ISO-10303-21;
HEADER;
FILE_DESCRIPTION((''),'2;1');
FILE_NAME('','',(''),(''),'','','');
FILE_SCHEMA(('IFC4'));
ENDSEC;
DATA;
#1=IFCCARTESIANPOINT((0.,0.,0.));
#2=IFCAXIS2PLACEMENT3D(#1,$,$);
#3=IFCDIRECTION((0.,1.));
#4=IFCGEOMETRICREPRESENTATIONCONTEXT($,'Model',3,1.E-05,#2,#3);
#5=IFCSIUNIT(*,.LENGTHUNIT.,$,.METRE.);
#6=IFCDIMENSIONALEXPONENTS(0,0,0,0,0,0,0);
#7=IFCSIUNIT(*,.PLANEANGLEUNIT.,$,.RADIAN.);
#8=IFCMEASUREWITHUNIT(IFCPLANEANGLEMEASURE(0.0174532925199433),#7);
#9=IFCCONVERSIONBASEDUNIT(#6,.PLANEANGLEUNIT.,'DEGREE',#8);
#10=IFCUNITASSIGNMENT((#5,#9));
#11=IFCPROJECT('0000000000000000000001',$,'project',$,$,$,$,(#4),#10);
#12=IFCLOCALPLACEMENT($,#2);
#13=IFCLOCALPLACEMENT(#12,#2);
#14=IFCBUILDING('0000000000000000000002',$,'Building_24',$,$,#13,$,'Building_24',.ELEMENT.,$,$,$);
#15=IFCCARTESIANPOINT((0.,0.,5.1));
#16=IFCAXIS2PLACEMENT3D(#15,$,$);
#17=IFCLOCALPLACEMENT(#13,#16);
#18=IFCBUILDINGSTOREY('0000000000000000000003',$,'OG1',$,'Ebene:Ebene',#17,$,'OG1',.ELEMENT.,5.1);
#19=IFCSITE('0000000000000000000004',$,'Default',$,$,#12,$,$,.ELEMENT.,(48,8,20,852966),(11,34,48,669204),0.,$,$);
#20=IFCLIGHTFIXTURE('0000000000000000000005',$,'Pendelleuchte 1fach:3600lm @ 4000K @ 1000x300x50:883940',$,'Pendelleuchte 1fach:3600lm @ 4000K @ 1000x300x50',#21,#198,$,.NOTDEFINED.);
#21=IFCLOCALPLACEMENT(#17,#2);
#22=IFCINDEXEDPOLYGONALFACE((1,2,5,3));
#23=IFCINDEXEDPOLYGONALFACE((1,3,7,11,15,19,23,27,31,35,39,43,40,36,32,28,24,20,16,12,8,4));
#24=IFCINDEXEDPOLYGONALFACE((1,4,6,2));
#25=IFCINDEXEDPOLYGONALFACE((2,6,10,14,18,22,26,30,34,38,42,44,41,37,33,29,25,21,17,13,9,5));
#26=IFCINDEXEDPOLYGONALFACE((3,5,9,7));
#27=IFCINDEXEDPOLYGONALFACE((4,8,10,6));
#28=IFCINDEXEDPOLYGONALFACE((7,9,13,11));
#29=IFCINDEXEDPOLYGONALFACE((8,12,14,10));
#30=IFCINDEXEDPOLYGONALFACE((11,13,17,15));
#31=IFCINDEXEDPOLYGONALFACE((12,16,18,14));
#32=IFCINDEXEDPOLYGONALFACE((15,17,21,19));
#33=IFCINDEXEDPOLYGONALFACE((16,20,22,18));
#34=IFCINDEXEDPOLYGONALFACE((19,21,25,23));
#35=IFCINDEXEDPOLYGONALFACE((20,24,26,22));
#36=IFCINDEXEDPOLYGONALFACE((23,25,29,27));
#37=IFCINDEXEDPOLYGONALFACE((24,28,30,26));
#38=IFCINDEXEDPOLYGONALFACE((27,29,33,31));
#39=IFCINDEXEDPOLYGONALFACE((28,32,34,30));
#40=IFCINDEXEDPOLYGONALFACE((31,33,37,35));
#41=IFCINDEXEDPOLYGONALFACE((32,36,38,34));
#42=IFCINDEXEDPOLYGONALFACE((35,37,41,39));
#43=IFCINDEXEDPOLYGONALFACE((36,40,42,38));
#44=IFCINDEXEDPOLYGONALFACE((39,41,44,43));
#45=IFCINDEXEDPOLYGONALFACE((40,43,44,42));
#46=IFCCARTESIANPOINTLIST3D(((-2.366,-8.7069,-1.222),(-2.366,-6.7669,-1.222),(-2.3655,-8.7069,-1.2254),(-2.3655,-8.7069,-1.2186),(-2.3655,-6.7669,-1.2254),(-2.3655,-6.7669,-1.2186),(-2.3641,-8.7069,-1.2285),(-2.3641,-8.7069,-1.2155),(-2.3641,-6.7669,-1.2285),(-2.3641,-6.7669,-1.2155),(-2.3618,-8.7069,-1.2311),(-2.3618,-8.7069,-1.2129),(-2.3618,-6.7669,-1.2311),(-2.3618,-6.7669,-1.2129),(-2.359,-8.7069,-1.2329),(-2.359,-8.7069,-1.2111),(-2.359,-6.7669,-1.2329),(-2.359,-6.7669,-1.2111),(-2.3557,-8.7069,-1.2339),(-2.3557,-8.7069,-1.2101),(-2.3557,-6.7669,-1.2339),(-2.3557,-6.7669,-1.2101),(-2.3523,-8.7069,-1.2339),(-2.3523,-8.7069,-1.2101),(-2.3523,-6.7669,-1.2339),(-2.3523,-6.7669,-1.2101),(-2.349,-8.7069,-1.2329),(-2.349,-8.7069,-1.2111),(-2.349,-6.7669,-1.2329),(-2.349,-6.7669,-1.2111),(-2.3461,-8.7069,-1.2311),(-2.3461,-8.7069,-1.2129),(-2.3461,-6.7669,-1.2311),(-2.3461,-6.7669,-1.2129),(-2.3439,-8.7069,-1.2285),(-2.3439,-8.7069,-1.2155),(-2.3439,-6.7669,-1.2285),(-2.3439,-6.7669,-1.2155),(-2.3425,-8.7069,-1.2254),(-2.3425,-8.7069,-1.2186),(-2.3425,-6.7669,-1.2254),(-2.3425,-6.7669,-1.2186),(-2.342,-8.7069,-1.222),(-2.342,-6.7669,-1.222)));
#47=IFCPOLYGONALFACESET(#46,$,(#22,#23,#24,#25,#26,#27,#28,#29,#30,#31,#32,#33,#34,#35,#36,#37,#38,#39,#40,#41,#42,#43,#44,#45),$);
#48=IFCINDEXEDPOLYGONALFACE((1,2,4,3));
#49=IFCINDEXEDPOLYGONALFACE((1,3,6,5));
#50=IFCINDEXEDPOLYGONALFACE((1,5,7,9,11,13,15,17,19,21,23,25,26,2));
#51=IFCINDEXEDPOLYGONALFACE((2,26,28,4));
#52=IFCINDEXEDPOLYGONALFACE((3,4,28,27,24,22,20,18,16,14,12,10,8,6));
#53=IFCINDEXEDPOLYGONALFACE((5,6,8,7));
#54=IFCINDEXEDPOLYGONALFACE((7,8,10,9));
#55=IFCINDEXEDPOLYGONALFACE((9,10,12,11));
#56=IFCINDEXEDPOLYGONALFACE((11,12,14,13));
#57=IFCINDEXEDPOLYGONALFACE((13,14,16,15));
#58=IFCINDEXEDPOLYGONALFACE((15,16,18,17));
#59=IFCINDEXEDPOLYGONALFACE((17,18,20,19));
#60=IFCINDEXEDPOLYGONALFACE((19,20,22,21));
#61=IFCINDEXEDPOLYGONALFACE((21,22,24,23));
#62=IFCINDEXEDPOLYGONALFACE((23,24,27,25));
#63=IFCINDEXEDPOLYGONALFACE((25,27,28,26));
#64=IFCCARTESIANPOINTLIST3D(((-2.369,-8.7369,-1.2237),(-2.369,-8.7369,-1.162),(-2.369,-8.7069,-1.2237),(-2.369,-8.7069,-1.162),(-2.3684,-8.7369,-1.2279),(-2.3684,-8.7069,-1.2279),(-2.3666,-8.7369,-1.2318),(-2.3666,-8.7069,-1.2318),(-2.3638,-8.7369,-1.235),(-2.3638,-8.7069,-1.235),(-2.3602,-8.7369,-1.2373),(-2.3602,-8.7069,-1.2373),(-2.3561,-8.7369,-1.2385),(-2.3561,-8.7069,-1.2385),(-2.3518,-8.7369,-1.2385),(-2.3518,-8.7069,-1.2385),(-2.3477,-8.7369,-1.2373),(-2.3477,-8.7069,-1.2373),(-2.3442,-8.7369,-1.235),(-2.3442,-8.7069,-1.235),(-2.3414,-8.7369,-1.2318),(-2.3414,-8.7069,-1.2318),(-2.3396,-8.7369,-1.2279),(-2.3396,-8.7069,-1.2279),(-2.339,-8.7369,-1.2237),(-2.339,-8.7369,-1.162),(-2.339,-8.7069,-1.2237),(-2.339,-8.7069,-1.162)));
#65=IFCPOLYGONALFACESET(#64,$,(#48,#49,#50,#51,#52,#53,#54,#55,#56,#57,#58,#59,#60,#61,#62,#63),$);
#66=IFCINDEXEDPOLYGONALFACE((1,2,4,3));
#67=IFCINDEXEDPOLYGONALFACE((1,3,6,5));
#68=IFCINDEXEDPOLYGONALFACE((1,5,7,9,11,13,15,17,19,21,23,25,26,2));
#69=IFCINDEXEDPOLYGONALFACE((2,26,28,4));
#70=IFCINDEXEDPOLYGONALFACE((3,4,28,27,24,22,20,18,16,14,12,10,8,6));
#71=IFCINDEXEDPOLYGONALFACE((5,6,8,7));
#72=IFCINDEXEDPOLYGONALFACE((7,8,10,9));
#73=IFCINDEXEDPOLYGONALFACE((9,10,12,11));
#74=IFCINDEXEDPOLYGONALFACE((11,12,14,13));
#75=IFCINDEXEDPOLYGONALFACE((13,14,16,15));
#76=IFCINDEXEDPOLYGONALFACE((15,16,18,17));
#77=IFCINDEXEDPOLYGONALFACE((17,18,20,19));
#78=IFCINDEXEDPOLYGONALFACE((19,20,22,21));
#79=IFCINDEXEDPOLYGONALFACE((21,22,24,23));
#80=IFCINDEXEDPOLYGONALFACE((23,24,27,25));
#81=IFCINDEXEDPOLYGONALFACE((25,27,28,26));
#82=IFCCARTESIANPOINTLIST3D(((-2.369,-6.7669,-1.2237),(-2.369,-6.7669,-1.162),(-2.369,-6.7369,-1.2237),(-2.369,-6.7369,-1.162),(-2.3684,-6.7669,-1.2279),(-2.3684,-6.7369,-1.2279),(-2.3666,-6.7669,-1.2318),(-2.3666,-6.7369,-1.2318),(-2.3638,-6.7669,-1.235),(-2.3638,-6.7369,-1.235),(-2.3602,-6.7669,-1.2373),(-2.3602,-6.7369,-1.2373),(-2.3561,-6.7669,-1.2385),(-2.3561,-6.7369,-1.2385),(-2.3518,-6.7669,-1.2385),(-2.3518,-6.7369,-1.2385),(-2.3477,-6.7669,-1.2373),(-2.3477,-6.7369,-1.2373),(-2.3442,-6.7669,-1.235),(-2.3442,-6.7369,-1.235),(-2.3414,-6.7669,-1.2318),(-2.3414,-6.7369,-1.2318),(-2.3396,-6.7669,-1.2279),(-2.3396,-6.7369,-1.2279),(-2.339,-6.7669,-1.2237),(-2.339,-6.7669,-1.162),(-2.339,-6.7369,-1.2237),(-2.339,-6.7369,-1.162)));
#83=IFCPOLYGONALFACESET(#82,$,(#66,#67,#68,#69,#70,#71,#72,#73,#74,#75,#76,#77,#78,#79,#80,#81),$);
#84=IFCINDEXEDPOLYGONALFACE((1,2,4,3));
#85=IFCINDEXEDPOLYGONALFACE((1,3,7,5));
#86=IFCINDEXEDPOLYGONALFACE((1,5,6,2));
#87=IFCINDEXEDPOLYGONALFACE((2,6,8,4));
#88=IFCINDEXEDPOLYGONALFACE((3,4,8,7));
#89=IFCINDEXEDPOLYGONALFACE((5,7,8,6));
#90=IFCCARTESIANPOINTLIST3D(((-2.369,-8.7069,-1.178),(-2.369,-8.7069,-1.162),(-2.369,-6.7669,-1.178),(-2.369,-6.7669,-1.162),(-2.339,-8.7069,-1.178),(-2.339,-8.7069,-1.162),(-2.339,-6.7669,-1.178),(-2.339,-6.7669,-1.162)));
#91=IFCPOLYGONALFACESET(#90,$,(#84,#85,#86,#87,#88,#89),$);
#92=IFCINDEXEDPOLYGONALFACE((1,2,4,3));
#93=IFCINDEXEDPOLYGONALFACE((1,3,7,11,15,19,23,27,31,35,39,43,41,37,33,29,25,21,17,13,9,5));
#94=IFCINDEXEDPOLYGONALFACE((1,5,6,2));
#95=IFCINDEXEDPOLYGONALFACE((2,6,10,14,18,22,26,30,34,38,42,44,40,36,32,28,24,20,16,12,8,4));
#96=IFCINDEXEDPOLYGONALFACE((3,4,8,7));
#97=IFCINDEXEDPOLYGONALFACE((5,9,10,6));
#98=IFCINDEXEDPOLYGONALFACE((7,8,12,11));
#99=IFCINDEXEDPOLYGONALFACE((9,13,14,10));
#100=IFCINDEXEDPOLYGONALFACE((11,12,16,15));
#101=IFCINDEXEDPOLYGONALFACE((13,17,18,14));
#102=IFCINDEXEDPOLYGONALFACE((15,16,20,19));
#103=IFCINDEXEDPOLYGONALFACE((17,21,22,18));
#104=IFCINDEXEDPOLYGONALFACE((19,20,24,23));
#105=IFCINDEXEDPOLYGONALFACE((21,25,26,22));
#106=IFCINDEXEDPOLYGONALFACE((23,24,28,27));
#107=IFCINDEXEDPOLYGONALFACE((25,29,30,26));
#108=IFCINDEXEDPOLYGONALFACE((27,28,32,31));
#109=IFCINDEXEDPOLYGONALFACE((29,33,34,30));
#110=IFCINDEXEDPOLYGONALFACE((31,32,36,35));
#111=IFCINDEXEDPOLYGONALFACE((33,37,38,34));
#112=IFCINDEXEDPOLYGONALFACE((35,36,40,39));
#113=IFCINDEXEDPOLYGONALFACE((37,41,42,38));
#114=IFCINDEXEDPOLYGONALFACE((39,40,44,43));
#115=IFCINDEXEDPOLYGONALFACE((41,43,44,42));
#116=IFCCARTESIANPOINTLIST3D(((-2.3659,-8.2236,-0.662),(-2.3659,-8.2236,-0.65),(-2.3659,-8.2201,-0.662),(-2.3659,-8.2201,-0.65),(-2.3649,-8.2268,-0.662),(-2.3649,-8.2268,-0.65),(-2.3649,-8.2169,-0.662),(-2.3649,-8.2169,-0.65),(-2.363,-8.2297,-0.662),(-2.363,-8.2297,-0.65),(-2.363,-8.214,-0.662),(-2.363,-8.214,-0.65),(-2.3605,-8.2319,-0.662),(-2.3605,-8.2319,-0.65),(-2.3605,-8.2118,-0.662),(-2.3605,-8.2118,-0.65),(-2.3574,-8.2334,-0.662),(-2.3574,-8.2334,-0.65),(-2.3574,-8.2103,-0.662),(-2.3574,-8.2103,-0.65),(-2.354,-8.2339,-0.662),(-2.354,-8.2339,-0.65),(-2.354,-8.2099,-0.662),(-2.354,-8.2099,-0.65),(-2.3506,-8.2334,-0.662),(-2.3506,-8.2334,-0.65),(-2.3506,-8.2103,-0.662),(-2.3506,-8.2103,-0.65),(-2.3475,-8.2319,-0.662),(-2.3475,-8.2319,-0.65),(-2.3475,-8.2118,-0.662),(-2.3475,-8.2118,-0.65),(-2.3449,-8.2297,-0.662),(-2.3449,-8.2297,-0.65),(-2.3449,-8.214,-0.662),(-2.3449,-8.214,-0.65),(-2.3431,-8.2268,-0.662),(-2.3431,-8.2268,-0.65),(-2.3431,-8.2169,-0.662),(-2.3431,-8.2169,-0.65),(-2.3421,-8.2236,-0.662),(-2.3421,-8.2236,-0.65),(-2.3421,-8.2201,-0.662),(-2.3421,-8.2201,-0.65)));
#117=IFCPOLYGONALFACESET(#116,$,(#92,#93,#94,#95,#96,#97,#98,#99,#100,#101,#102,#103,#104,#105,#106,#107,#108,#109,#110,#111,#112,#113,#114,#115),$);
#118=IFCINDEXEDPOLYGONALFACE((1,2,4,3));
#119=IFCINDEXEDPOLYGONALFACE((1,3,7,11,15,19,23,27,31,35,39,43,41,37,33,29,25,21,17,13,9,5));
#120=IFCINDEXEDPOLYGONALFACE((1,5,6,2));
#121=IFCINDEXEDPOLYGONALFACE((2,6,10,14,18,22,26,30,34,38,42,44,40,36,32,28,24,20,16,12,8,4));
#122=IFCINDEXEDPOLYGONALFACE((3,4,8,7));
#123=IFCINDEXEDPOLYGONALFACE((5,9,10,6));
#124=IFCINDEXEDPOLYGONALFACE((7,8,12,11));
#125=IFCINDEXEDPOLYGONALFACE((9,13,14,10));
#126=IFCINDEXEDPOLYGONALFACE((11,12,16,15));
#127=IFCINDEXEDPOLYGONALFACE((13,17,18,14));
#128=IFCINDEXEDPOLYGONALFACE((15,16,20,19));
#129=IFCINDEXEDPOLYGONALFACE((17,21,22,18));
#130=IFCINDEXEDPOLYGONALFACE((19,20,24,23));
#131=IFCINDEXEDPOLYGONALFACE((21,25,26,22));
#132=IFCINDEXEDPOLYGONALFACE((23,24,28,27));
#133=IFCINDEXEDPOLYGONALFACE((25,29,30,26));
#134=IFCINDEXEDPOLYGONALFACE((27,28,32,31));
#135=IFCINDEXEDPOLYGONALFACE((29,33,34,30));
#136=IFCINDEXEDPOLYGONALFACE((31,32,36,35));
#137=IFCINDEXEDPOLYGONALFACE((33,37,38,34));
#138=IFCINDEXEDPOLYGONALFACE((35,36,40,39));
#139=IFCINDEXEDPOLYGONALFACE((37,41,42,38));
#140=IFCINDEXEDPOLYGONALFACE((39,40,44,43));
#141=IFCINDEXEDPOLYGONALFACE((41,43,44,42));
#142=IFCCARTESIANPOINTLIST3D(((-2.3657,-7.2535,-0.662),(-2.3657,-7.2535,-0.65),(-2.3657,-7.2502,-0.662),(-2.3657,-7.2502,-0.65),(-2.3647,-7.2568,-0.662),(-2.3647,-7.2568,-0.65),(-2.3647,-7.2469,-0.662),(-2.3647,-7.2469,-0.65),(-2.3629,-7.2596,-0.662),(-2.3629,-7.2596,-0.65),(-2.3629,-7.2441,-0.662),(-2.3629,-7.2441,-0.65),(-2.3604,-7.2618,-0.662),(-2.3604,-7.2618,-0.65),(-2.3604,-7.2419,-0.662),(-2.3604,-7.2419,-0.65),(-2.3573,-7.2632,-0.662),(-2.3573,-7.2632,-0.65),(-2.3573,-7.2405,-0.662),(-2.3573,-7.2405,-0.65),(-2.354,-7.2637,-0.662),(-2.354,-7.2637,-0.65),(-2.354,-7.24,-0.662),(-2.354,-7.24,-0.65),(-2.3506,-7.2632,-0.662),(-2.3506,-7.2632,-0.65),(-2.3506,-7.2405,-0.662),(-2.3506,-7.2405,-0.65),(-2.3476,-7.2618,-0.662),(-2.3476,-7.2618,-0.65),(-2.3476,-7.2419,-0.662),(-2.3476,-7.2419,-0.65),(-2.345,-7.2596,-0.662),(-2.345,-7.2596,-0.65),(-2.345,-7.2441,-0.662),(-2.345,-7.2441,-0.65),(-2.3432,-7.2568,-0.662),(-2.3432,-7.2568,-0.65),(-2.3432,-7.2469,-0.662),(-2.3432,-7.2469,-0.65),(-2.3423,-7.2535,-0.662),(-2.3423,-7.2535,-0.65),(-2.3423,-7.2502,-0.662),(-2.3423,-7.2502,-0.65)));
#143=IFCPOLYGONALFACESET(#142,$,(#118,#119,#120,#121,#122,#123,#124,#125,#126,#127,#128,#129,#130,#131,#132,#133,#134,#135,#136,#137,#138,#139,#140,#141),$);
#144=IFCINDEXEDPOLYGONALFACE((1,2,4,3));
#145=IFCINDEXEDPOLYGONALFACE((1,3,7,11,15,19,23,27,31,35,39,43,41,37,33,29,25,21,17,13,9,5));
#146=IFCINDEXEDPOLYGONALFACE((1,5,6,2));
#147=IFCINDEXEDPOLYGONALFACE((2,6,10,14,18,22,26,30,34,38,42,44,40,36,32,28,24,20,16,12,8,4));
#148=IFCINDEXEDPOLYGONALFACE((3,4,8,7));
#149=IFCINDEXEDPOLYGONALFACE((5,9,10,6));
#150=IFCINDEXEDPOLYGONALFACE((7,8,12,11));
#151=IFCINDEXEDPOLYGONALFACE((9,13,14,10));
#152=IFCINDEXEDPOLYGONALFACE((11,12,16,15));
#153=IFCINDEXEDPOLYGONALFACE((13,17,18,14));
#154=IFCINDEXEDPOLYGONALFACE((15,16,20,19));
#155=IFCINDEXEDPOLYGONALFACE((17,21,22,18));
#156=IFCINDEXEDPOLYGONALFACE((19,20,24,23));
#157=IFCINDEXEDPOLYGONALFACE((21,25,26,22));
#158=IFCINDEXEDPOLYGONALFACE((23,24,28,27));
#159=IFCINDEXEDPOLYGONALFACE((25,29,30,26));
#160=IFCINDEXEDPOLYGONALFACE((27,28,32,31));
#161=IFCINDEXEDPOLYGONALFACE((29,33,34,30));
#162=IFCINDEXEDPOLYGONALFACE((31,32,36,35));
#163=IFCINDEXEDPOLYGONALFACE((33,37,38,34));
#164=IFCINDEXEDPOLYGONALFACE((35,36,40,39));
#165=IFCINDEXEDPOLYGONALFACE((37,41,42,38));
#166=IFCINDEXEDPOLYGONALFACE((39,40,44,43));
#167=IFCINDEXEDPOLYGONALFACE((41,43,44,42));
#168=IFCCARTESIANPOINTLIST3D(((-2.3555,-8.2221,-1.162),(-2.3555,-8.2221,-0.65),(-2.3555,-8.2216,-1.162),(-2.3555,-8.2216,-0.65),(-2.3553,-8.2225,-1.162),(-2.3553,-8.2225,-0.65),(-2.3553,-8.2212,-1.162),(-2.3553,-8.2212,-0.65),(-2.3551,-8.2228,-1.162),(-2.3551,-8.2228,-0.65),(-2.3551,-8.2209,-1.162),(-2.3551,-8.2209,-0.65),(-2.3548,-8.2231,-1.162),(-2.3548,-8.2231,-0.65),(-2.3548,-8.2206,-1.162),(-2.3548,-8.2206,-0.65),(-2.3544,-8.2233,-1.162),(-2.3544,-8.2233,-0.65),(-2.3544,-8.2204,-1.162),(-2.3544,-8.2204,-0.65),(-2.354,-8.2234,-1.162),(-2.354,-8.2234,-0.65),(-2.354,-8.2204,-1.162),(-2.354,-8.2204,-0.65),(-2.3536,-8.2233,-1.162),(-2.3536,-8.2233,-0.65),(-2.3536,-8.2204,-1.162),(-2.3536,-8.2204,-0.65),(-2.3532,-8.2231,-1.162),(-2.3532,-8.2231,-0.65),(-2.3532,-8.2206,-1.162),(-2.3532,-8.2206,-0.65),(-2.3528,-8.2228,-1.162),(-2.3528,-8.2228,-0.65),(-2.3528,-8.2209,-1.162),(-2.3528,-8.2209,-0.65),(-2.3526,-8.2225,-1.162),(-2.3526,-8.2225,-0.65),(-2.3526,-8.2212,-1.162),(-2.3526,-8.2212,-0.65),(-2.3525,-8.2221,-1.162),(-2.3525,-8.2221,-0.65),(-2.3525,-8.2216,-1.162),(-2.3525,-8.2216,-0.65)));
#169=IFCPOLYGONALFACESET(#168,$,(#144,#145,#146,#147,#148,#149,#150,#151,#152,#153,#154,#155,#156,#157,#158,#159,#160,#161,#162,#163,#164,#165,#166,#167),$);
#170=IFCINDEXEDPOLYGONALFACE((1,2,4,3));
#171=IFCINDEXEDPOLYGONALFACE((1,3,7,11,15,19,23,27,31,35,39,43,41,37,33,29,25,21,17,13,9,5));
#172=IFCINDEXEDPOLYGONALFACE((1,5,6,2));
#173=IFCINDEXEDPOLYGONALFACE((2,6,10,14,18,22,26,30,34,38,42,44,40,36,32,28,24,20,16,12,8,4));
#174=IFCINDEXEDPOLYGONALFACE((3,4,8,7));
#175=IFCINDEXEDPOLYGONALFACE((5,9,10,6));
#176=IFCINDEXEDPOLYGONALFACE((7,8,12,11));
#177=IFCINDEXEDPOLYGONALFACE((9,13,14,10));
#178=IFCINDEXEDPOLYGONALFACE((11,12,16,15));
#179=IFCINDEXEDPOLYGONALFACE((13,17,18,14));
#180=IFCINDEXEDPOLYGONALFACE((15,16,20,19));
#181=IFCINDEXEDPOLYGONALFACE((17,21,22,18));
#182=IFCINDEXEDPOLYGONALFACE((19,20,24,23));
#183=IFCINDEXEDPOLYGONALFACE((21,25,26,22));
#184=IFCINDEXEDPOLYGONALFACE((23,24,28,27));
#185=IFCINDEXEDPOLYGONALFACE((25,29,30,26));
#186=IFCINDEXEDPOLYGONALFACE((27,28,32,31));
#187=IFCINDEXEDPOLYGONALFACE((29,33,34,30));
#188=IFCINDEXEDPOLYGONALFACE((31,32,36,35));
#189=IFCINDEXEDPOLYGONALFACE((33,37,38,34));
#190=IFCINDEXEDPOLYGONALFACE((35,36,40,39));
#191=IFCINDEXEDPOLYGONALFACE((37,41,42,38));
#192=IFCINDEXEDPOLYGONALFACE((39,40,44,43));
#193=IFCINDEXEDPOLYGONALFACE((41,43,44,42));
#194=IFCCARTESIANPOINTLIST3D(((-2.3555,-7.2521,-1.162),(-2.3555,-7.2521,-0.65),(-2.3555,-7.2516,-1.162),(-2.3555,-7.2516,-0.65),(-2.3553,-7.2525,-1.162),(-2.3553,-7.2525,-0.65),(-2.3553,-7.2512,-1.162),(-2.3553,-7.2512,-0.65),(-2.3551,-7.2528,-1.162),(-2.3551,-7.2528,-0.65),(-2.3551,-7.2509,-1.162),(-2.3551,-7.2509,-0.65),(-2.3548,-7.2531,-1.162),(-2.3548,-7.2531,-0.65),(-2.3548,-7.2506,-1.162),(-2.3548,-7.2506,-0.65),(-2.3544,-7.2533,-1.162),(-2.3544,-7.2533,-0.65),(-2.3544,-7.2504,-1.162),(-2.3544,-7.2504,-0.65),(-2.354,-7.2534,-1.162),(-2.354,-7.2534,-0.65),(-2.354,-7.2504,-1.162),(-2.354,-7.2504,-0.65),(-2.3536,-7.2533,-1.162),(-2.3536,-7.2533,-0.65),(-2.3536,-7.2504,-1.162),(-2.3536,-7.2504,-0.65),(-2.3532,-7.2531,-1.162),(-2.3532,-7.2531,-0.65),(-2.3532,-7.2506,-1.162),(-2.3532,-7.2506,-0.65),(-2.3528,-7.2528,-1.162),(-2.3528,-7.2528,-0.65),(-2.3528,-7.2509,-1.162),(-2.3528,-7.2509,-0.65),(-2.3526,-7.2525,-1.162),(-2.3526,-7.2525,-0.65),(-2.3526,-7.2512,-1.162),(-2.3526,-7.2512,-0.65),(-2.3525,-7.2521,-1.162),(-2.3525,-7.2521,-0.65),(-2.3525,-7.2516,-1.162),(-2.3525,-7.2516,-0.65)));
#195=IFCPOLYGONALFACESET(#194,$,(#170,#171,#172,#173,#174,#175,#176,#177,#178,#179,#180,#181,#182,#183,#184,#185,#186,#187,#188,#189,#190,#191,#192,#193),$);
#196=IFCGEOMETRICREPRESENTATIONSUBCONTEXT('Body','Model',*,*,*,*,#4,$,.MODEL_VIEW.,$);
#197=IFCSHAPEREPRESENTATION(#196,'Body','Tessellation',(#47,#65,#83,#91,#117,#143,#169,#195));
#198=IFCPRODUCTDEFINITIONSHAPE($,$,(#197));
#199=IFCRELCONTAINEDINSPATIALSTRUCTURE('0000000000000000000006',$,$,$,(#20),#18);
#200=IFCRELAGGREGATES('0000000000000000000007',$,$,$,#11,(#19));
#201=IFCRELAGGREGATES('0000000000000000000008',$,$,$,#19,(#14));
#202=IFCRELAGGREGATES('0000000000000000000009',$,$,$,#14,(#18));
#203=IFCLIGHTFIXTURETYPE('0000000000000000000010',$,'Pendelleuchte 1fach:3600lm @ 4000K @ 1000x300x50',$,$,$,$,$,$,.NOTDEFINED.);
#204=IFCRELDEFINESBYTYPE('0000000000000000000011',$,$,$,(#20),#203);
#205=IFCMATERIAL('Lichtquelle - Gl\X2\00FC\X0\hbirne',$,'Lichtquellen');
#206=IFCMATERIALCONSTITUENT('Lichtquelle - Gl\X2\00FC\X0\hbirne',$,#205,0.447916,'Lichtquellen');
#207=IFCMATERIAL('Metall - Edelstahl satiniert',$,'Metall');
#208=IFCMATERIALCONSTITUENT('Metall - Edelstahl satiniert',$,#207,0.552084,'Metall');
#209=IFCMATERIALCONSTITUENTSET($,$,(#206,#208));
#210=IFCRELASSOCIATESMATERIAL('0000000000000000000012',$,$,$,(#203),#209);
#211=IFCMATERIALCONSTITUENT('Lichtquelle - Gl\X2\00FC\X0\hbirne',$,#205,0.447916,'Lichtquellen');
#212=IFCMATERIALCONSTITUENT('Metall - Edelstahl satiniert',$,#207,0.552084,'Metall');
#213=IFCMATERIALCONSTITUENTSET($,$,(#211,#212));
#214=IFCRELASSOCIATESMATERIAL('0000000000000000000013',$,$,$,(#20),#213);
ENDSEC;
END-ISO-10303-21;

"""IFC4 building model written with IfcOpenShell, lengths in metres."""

from ifc_helpers import new_model, entity, si_unit, converted_unit, direction, frame, origin, place, context, subcontext, project, spatial, line, arc, indexed_curve, outline, extrude, source, transform, mapped, material, constituent, constituent_set, type_object, type_shapes, element, save


model = new_model("IFC4")

# Units and contexts
model_context = context("Model", 3, precision=1e-05, world=origin(), true_north=direction((0.0, 1.0)))
body_context = subcontext(model_context, "Body", "Model", "MODEL_VIEW")
ifc_project = project(units=[si_unit("LENGTHUNIT", "METRE"), converted_unit("PLANEANGLEUNIT", "DEGREE", entity("IfcPlaneAngleMeasure", 0.0174532925199433), si_unit("PLANEANGLEUNIT", "RADIAN"), dimensions=[0, 0, 0, 0, 0, 0, 0])], contexts=[model_context])

# Site, building, storey
site_placement = place(None, origin())
site = spatial("IfcSite", under=ifc_project, at=site_placement, Name="Default", CompositionType="ELEMENT", RefLatitude=(48, 8, 20, 852966), RefLongitude=(11, 34, 48, 669204), RefElevation=0.0)
building_placement = place(site_placement, origin())
building = spatial("IfcBuilding", under=site, at=building_placement, Name="Building_24", LongName="Building_24", CompositionType="ELEMENT")
storey_placement = place(building_placement, frame((0.0, 0.0, 5.1)))
storey = spatial("IfcBuildingStorey", under=building, at=storey_placement, Name="OG1", ObjectType="Ebene:Ebene", LongName="OG1", CompositionType="ELEMENT", Elevation=5.1)

# Light fixture
ifc_material_1 = material(Name="Lichtquelle - Glühbirne", Category="Lichtquellen")
ifc_material_2 = material(Name="Metall - Edelstahl satiniert", Category="Metall")
ifc_constituent_1 = constituent(ifc_material_1, Name="Lichtquelle - Glühbirne", Category="Lichtquellen", fraction=0.447916)
ifc_constituent_2 = constituent(ifc_material_2, Name="Metall - Edelstahl satiniert", Category="Metall", fraction=0.552084)
ifc_constituent_set_1 = constituent_set(constituents=[ifc_constituent_1, ifc_constituent_2])
light_fixture_type_1 = type_object("IfcLightFixtureType", Name="Pendelleuchte 1fach:3600lm @ 4000K @ 1000x300x50", PredefinedType="NOTDEFINED", material=ifc_constituent_set_1)
shared_shape_1 = source(origin(), body_context, "Body", "SweptSolid", [
    extrude(outline(indexed_curve([(-0.012, 0.0), (0.0, -0.012), (0.012, 0.0), (0.0, 0.012)], segments=[arc(1, 2, 3), arc(3, 4, 1)], self_intersect=False)), frame((-0.97, 0.0, -0.572), z_axis=(1.0, 0.0, 0.0), x_axis=(0.0, 1.0, 0.0)), (0.0, 0.0, 1.0), 1.94),
    extrude(outline(indexed_curve([(-0.0308, -0.015), (0.0308, -0.015), (0.0308, 0.015), (-0.0308, 0.015), (-0.0458, 0.0)], segments=[line(1, 2, 3, 4), arc(4, 5, 1)], self_intersect=False)), frame((0.97, 0.0, -0.5428), z_axis=(1.0, 0.0, 0.0), x_axis=(0.0, 0.0, 1.0)), (0.0, 0.0, 1.0), 0.03),
    extrude(outline(indexed_curve([(-0.0308, -0.015), (0.0308, -0.015), (0.0308, 0.015), (-0.0308, 0.015), (-0.0458, 0.0)], segments=[line(1, 2, 3, 4), arc(4, 5, 1)], self_intersect=False)), frame((-1.0, 0.0, -0.5428), z_axis=(1.0, 0.0, 0.0), x_axis=(0.0, 0.0, 1.0)), (0.0, 0.0, 1.0), 0.03),
    extrude(outline(indexed_curve([(-0.97, -0.015), (0.97, -0.015), (0.97, 0.015), (-0.97, 0.015), (-0.97, -0.015)], self_intersect=False)), frame((0.0, 0.0, -0.528), z_axis=(0.0, 0.0, 1.0), x_axis=(-1.0, 0.0, 0.0)), (0.0, 0.0, 1.0), 0.016),
    extrude(outline(indexed_curve([(-0.012, 0.0), (0.0, -0.012), (0.012, 0.0), (0.0, 0.012)], segments=[arc(1, 2, 3), arc(3, 4, 1)], self_intersect=False)), frame((0.485, 0.0, -0.012)), (0.0, 0.0, 1.0), 0.012),
    extrude(outline(indexed_curve([(-0.0118, 0.0), (0.0, -0.0118), (0.0118, 0.0), (0.0, 0.0118)], segments=[arc(1, 2, 3), arc(3, 4, 1)], self_intersect=False)), frame((-0.485, 0.0, -0.012)), (0.0, 0.0, 1.0), 0.012),
    extrude(outline(indexed_curve([(-0.0015, 0.0), (0.0, -0.0015), (0.0015, 0.0), (0.0, 0.0015)], segments=[arc(1, 2, 3), arc(3, 4, 1)], self_intersect=False)), frame((0.485, 0.0, -0.512)), (0.0, 0.0, 1.0), 0.512),
    extrude(outline(indexed_curve([(-0.0015, 0.0), (0.0, -0.0015), (0.0015, 0.0), (0.0, 0.0015)], segments=[arc(1, 2, 3), arc(3, 4, 1)], self_intersect=False)), frame((-0.485, 0.0, -0.512)), (0.0, 0.0, 1.0), 0.512),
])
type_shapes(light_fixture_type_1, [shared_shape_1])
ifc_constituent_3 = constituent(ifc_material_1, Name="Lichtquelle - Glühbirne", Category="Lichtquellen", fraction=0.447916)
ifc_constituent_4 = constituent(ifc_material_2, Name="Metall - Edelstahl satiniert", Category="Metall", fraction=0.552084)
ifc_constituent_set_2 = constituent_set(constituents=[ifc_constituent_3, ifc_constituent_4])
light_fixture_1_placement = place(storey_placement, frame((-2.354, -7.7369, -0.65), z_axis=(0.0, 0.0, 1.0), x_axis=(0.0, -1.0, 0.0)))
element("IfcLightFixture", 1, at=light_fixture_1_placement, inside=storey, type_object=light_fixture_type_1, material=ifc_constituent_set_2, Name="Pendelleuchte 1fach:3600lm @ 4000K @ 1000x300x50:883940", ObjectType="Pendelleuchte 1fach:3600lm @ 4000K @ 1000x300x50", PredefinedType="NOTDEFINED", context=body_context, shape_type="MappedRepresentation", body=[
    mapped(shared_shape_1, transform((0.0, 0.0, 0.0), scale=1.0)),
])

save(model, "model.ifc")
